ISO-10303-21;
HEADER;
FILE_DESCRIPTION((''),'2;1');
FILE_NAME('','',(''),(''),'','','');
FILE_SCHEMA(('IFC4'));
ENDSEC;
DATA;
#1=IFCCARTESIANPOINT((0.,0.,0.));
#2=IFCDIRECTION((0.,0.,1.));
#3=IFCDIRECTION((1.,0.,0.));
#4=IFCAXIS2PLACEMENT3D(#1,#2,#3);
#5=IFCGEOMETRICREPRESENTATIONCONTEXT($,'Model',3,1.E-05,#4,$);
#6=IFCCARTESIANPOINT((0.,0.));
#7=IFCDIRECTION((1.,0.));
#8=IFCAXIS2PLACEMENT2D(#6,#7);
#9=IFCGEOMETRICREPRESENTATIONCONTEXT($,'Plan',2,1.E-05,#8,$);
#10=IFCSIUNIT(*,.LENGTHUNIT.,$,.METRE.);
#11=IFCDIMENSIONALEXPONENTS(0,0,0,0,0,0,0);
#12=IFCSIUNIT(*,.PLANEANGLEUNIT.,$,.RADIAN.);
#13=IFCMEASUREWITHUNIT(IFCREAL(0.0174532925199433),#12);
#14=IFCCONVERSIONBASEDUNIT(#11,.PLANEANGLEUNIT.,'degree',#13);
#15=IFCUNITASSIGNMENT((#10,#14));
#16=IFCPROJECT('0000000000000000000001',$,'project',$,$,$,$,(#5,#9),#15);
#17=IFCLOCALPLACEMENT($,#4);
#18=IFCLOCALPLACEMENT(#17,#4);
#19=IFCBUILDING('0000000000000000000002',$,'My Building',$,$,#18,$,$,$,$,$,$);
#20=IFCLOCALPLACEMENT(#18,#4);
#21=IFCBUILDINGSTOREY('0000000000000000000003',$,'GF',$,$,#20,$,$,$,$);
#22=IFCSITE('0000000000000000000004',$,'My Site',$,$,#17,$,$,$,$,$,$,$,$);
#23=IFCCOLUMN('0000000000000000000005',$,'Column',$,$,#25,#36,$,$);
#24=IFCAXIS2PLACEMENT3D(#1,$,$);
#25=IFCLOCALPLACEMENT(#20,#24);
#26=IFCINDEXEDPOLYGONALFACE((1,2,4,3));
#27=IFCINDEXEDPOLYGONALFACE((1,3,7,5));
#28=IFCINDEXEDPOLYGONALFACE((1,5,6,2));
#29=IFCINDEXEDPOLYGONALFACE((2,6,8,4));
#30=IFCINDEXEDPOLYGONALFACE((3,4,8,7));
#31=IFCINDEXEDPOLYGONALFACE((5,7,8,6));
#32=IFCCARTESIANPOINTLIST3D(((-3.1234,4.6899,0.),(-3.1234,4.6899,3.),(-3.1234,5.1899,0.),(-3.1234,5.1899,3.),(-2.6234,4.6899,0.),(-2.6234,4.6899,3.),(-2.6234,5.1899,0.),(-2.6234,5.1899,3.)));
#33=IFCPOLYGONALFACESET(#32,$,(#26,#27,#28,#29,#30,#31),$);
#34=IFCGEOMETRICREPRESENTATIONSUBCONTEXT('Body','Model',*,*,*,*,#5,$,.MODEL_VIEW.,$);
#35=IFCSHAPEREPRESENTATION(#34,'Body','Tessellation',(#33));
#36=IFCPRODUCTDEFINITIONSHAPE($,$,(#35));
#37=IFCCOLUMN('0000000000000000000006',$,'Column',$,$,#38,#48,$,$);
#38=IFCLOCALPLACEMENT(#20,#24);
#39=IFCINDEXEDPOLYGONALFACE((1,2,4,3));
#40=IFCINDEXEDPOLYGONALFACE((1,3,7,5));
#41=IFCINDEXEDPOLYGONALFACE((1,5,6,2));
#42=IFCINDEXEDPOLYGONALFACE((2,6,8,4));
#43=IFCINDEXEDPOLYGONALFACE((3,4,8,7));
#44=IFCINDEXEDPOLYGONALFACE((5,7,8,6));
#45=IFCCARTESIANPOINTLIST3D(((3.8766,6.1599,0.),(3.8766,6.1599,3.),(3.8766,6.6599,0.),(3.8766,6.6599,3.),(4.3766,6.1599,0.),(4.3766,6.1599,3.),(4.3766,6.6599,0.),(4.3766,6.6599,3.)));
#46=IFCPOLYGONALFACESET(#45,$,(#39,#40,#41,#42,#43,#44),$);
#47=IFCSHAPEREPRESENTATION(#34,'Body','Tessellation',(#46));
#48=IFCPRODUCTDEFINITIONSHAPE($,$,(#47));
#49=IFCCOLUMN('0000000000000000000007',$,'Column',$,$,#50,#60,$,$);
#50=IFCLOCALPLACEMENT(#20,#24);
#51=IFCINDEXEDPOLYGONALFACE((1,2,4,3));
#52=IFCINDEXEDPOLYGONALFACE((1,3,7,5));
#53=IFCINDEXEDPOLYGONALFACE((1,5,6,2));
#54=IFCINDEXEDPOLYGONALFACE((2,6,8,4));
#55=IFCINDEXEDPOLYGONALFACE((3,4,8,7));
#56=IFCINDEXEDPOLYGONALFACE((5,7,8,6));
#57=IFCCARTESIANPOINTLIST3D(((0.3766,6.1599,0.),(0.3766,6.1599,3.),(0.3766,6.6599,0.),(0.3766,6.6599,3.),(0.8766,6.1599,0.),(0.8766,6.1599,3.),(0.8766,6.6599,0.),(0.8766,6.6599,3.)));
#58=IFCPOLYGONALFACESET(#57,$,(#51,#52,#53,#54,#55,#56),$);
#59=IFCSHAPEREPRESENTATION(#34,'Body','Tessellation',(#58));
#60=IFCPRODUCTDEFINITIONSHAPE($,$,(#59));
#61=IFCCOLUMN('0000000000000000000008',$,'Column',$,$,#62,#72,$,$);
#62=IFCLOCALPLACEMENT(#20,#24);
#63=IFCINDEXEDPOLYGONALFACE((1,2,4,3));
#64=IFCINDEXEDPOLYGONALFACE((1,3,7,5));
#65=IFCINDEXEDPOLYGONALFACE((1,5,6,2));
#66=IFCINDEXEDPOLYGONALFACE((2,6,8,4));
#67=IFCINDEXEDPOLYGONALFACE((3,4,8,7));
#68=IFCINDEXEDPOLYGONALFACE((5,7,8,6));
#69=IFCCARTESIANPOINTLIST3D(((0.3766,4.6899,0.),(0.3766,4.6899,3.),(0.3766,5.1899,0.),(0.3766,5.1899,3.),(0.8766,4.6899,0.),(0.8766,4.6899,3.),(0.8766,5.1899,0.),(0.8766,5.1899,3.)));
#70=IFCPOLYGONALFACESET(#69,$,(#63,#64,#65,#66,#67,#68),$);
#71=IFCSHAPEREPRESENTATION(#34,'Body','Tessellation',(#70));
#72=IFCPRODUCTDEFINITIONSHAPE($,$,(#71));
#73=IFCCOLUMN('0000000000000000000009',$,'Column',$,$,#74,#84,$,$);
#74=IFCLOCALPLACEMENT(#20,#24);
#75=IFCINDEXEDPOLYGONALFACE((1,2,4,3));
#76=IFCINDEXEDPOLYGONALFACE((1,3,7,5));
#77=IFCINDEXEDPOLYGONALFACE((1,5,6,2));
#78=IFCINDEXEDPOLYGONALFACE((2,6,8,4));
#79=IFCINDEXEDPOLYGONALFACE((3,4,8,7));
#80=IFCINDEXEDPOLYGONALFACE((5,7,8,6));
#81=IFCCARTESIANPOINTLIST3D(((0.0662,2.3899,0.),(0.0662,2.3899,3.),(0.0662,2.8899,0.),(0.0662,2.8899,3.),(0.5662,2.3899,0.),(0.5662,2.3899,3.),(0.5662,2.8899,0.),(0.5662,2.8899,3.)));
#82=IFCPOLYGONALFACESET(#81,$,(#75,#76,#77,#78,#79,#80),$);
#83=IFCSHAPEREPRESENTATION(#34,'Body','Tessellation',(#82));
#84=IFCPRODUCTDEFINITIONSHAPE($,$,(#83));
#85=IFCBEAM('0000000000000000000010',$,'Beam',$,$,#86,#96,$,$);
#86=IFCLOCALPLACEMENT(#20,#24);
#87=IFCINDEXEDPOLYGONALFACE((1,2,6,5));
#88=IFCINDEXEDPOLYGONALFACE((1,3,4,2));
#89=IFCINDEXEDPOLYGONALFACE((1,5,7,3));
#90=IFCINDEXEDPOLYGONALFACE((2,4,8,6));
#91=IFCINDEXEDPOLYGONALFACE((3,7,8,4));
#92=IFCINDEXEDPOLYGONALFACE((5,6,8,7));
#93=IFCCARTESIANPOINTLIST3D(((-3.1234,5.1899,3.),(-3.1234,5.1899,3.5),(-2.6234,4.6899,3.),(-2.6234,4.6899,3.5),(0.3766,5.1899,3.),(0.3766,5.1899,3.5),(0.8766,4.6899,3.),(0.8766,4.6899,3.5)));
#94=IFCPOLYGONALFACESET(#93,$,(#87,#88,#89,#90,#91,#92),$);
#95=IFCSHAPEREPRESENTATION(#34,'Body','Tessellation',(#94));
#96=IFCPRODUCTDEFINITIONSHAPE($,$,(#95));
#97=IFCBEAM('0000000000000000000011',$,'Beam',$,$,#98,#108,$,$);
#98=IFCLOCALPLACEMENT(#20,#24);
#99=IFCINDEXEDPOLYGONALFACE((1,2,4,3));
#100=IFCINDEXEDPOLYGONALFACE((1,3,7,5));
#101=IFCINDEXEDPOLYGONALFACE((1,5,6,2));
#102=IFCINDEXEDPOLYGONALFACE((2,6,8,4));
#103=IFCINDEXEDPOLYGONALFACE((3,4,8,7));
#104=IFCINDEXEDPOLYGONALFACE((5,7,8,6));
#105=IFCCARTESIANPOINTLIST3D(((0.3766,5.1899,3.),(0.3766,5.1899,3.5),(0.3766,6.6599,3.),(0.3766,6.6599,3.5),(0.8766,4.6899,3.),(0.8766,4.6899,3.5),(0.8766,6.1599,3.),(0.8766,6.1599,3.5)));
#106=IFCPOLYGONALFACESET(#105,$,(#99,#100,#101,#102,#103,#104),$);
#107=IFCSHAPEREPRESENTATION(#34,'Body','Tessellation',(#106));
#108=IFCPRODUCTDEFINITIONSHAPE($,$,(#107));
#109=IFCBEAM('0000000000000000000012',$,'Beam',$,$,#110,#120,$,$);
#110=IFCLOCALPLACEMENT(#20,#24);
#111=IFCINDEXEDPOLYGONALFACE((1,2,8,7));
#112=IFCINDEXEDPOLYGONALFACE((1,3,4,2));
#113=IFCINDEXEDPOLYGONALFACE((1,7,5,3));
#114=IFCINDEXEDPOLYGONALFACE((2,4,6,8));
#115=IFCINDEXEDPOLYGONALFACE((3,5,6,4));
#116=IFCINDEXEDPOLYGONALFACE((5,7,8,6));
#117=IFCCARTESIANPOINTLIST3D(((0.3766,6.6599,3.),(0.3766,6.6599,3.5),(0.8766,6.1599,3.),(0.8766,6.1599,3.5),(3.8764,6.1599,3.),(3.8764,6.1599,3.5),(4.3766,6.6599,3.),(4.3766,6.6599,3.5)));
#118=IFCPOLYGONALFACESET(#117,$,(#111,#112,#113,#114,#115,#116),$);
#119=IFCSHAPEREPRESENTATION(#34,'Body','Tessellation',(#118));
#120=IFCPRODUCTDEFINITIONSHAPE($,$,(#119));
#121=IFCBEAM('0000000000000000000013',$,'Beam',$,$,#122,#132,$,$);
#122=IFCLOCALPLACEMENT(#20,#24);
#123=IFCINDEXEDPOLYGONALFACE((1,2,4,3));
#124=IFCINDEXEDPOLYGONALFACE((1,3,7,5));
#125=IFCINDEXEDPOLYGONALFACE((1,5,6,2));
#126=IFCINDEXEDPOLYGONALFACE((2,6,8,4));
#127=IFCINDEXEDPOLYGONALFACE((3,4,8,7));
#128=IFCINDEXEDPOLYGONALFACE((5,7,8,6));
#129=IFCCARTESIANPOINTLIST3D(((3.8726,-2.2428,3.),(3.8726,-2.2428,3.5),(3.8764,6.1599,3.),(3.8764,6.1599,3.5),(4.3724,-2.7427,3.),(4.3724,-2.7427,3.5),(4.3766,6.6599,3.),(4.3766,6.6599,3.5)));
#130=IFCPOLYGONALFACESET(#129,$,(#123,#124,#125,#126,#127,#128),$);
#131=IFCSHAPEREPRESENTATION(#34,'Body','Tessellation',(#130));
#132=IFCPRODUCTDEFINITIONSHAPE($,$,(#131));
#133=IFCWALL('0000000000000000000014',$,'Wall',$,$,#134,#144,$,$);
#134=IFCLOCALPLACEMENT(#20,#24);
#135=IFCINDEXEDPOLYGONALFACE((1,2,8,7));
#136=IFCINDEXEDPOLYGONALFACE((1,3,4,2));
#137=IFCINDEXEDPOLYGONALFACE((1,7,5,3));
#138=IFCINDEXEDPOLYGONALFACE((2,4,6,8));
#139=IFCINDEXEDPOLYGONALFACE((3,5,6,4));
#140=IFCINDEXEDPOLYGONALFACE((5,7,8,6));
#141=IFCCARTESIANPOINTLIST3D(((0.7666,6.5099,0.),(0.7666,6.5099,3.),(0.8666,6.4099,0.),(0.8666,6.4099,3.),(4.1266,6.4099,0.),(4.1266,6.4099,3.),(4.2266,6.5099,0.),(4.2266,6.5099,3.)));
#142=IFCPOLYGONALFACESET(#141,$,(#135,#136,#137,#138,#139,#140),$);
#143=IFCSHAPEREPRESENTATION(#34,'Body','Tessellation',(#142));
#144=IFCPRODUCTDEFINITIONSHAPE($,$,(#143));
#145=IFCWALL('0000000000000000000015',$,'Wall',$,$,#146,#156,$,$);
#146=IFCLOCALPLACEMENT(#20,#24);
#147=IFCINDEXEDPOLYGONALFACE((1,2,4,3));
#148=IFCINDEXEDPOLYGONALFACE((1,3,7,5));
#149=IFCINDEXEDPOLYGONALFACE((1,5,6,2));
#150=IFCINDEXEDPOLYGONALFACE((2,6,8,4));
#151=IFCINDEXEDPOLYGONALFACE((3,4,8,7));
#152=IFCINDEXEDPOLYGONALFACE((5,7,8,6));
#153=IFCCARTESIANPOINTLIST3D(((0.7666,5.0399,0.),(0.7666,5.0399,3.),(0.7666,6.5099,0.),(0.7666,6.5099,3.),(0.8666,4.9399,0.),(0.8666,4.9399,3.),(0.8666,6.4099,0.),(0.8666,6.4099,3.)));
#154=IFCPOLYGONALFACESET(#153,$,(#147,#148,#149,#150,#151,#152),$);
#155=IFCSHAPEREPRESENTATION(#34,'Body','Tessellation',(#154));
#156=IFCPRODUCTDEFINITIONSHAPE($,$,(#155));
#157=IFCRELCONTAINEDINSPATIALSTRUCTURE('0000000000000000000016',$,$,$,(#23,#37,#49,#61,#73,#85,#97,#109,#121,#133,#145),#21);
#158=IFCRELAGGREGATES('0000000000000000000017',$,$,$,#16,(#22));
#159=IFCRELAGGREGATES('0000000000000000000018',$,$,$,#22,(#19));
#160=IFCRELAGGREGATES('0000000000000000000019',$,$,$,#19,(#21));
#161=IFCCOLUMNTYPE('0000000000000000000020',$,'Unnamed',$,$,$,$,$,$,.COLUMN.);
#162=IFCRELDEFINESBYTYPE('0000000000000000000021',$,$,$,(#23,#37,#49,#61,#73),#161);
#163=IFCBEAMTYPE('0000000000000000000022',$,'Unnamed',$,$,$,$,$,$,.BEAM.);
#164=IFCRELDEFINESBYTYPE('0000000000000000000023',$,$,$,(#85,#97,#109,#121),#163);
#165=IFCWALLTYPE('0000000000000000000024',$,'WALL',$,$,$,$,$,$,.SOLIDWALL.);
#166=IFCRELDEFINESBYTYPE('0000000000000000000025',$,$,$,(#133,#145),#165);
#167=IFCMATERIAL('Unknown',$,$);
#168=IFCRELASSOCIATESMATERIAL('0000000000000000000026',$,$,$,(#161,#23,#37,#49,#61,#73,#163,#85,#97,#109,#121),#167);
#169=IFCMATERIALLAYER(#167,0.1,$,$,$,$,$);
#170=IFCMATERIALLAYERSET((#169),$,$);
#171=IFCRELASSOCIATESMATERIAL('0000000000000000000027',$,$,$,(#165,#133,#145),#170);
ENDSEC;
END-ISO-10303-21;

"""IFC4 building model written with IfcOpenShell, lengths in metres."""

from ifc_helpers import new_model, entity, si_unit, converted_unit, frame, origin_with_axes, origin_2d_with_axis, place, context, subcontext, project, spatial, line, indexed_curve, rectangle, outline, extrude, clip, halfspace, material, layer, layer_set, layer_usage, material_profile, profile_set, profile_usage, type_object, element, save


model = new_model("IFC4")

# Units and contexts
model_context = context("Model", 3, precision=1e-05, world=origin_with_axes())
plan_context = context("Plan", 2, precision=1e-05, world=origin_2d_with_axis())
body_context_1 = subcontext(model_context, "Body", "Model", "MODEL_VIEW")
ifc_project = project(units=[si_unit("LENGTHUNIT", "METRE"), converted_unit("PLANEANGLEUNIT", "degree", entity("IfcReal", 0.0174532925199433), si_unit("PLANEANGLEUNIT", "RADIAN"), dimensions=[0, 0, 0, 0, 0, 0, 0])], contexts=[model_context, plan_context])

# Site, building, storey
site_placement = place(None, origin_with_axes())
site = spatial("IfcSite", under=ifc_project, at=site_placement, Name="My Site")
building_placement = place(site_placement, origin_with_axes())
building = spatial("IfcBuilding", under=site, at=building_placement, Name="My Building")
storey_placement = place(building_placement, origin_with_axes())
storey = spatial("IfcBuildingStorey", under=building, at=storey_placement, Name="GF")

# Columns
ifc_material = material(Name="Unknown")
ifc_material_profile_1 = material_profile(ifc_material, rectangle(XDim=0.5, YDim=0.5))
ifc_profile_set_1 = profile_set([ifc_material_profile_1])
ifc_profile_usage_1 = profile_usage(ifc_profile_set_1, cardinal=5)
column_type = type_object("IfcColumnType", Name="Unnamed", PredefinedType="COLUMN", material=ifc_profile_set_1)
column_1_placement = place(storey_placement, frame((-2.8734, 4.9399, 0.0), z_axis=(0.0, 0.0, 1.0), x_axis=(1.0, 0.0, 0.0)))
element("IfcColumn", 1, at=column_1_placement, inside=storey, type_object=column_type, material=ifc_profile_usage_1, Name="Column", context=body_context_1, shape_type="SweptSolid", body=[
    extrude(rectangle(XDim=0.5, YDim=0.5), origin_with_axes(), (0.0, 0.0, 1.0), 3.0),
])
ifc_profile_usage_2 = profile_usage(ifc_profile_set_1, cardinal=5)
column_2_placement = place(storey_placement, frame((4.1266, 6.4099, 0.0), z_axis=(0.0, 0.0, 1.0), x_axis=(1.0, 0.0, 0.0)))
element("IfcColumn", 2, at=column_2_placement, inside=storey, type_object=column_type, material=ifc_profile_usage_2, Name="Column", context=body_context_1, shape_type="SweptSolid", body=[
    extrude(rectangle(XDim=0.5, YDim=0.5), origin_with_axes(), (0.0, 0.0, 1.0), 3.0),
])
ifc_profile_usage_3 = profile_usage(ifc_profile_set_1, cardinal=5)
column_3_placement = place(storey_placement, frame((0.6266, 6.4099, 0.0), z_axis=(0.0, 0.0, 1.0), x_axis=(1.0, 0.0, 0.0)))
element("IfcColumn", 3, at=column_3_placement, inside=storey, type_object=column_type, material=ifc_profile_usage_3, Name="Column", context=body_context_1, shape_type="SweptSolid", body=[
    extrude(rectangle(XDim=0.5, YDim=0.5), origin_with_axes(), (0.0, 0.0, 1.0), 3.0),
])
ifc_profile_usage_4 = profile_usage(ifc_profile_set_1, cardinal=5)
column_4_placement = place(storey_placement, frame((0.6266, 4.9399, 0.0), z_axis=(0.0, 0.0, 1.0), x_axis=(1.0, 0.0, 0.0)))
element("IfcColumn", 4, at=column_4_placement, inside=storey, type_object=column_type, material=ifc_profile_usage_4, Name="Column", context=body_context_1, shape_type="SweptSolid", body=[
    extrude(rectangle(XDim=0.5, YDim=0.5), origin_with_axes(), (0.0, 0.0, 1.0), 3.0),
])
ifc_profile_usage_5 = profile_usage(ifc_profile_set_1, cardinal=5)
column_5_placement = place(storey_placement, frame((0.3162, 2.6399, 0.0), z_axis=(0.0, 0.0, 1.0), x_axis=(1.0, 0.0, 0.0)))
element("IfcColumn", 5, at=column_5_placement, inside=storey, type_object=column_type, material=ifc_profile_usage_5, Name="Column", context=body_context_1, shape_type="SweptSolid", body=[
    extrude(rectangle(XDim=0.5, YDim=0.5), origin_with_axes(), (0.0, 0.0, 1.0), 3.0),
])

# Beams
ifc_material_profile_2 = material_profile(ifc_material, rectangle(XDim=0.5, YDim=0.5))
ifc_profile_set_2 = profile_set([ifc_material_profile_2])
ifc_profile_usage_6 = profile_usage(ifc_profile_set_2, cardinal=1)
beam_type = type_object("IfcBeamType", Name="Unnamed", PredefinedType="BEAM", material=ifc_profile_set_2)
beam_1_placement = place(storey_placement, frame((-3.1234, 5.1899, 3.0), z_axis=(1.0, 0.0, 0.0), x_axis=(0.0, 1.0, 0.0)))
element("IfcBeam", 6, at=beam_1_placement, inside=storey, type_object=beam_type, material=ifc_profile_usage_6, Name="Beam", context=body_context_1, shape_type="Clipping", body=[
    clip(clip(extrude(rectangle(XDim=0.5, YDim=0.5), frame((-0.25, 0.25, 0.0), z_axis=(0.0, 0.0, 1.0), x_axis=(1.0, 0.0, 0.0)), (0.0, 0.0, 1.0), 4.0), halfspace(frame((-0.5, -3.0, 4.0), z_axis=(0.707107, 0.0, 0.707107), x_axis=(0.0, -1.0, 0.0)), False)), halfspace(frame((0.0, -3.0, 0.0), z_axis=(-0.707107, 0.0, -0.707106), x_axis=(0.0, 1.0, 0.0)), False)),
])
ifc_profile_usage_7 = profile_usage(ifc_profile_set_2, cardinal=1)
beam_2_placement = place(storey_placement, frame((0.3766, 4.6899, 3.0), z_axis=(0.0, 1.0, 0.0), x_axis=(-1.0, 0.0, 0.0)))
element("IfcBeam", 7, at=beam_2_placement, inside=storey, type_object=beam_type, material=ifc_profile_usage_7, Name="Beam", context=body_context_1, shape_type="Clipping", body=[
    clip(clip(extrude(rectangle(XDim=0.5, YDim=0.5), frame((-0.25, 0.25, 0.0), z_axis=(0.0, 0.0, 1.0), x_axis=(1.0, 0.0, 0.0)), (0.0, 0.0, 1.0), 1.97), halfspace(frame((0.0, -3.0, 1.97), z_axis=(-0.707107, 0.0, 0.707107), x_axis=(0.0, 1.0, 0.0)), False)), halfspace(frame((-0.5, -3.0, 0.0), z_axis=(0.707107, 0.0, -0.707106), x_axis=(0.0, -1.0, 0.0)), False)),
])
ifc_profile_usage_8 = profile_usage(ifc_profile_set_2, cardinal=1)
beam_3_placement = place(storey_placement, frame((0.3766, 6.6599, 3.0), z_axis=(1.0, 0.0, 0.0), x_axis=(0.0, 1.0, 0.0)))
element("IfcBeam", 8, at=beam_3_placement, inside=storey, type_object=beam_type, material=ifc_profile_usage_8, Name="Beam", context=body_context_1, shape_type="Clipping", body=[
    clip(clip(extrude(rectangle(XDim=0.5, YDim=0.5), frame((-0.25, 0.25, 0.0), z_axis=(0.0, 0.0, 1.0), x_axis=(1.0, 0.0, 0.0)), (0.0, 0.0, 1.0), 4.5), halfspace(frame((0.0, -3.0, 4.0), z_axis=(-0.707264, 0.0, 0.70695), x_axis=(0.0, 1.0, 0.0)), False)), halfspace(frame((0.0, -3.0, 0.0), z_axis=(-0.707107, 0.0, -0.707107), x_axis=(0.0, 1.0, 0.0)), False)),
])
ifc_profile_usage_9 = profile_usage(ifc_profile_set_2, cardinal=1)
beam_4_placement = place(storey_placement, frame((4.3768, 7.1599, 3.0), z_axis=(-0.000445, -1.0, 0.0), x_axis=(1.0, -0.000445, 0.0)))
element("IfcBeam", 9, at=beam_4_placement, inside=storey, type_object=beam_type, material=ifc_profile_usage_9, Name="Beam", context=body_context_1, shape_type="Clipping", body=[
    clip(clip(extrude(rectangle(XDim=0.5, YDim=0.5), frame((-0.25, 0.25, 0.0), z_axis=(0.0, 0.0, 1.0), x_axis=(1.0, 0.0, 0.0)), (0.0, 0.0, 1.0), 10.4026), halfspace(frame((0.0, -3.0, 9.9026), z_axis=(-0.706868, 0.0, 0.707345), x_axis=(0.0, 1.0, 0.0)), False)), halfspace(frame((0.0, -3.0, 0.5), z_axis=(-0.707264, 0.0, -0.706949), x_axis=(0.0, 1.0, 0.0)), False)),
])

# Walls
ifc_layer = layer(ifc_material, 0.1)
ifc_layer_set = layer_set([ifc_layer])
ifc_layer_usage_1 = layer_usage(ifc_layer_set, "AXIS2", "POSITIVE", 0.0)
wall_type = type_object("IfcWallType", Name="WALL", PredefinedType="SOLIDWALL", material=ifc_layer_set)
wall_1_placement = place(storey_placement, frame((4.2266, 6.5099, 0.0), z_axis=(0.0, 0.0, 1.0), x_axis=(-1.0, 0.0, 0.0)))
element("IfcWall", 10, at=wall_1_placement, inside=storey, type_object=wall_type, material=ifc_layer_usage_1, Name="Wall", context=body_context_1, shape_type="SweptSolid", body=[
    extrude(outline(indexed_curve([(0.0, 0.0), (0.1, 0.1), (3.36, 0.1), (3.46, 0.0)], segments=[line(1, 2, 3, 4, 1)])), origin_with_axes(), (0.0, 0.0, 1.0), 3.0),
])
ifc_layer_usage_2 = layer_usage(ifc_layer_set, "AXIS2", "POSITIVE", 0.0)
wall_2_placement = place(storey_placement, frame((0.7666, 6.5099, 0.0), z_axis=(0.0, 0.0, 1.0), x_axis=(0.0, -1.0, 0.0)))
element("IfcWall", 11, at=wall_2_placement, inside=storey, type_object=wall_type, material=ifc_layer_usage_2, Name="Wall", context=body_context_1, shape_type="SweptSolid", body=[
    extrude(outline(indexed_curve([(0.0, 0.0), (0.1, 0.1), (1.57, 0.1), (1.47, 0.0)], segments=[line(1, 2, 3, 4, 1)])), origin_with_axes(), (0.0, 0.0, 1.0), 3.0),
])

save(model, "model.ifc")
